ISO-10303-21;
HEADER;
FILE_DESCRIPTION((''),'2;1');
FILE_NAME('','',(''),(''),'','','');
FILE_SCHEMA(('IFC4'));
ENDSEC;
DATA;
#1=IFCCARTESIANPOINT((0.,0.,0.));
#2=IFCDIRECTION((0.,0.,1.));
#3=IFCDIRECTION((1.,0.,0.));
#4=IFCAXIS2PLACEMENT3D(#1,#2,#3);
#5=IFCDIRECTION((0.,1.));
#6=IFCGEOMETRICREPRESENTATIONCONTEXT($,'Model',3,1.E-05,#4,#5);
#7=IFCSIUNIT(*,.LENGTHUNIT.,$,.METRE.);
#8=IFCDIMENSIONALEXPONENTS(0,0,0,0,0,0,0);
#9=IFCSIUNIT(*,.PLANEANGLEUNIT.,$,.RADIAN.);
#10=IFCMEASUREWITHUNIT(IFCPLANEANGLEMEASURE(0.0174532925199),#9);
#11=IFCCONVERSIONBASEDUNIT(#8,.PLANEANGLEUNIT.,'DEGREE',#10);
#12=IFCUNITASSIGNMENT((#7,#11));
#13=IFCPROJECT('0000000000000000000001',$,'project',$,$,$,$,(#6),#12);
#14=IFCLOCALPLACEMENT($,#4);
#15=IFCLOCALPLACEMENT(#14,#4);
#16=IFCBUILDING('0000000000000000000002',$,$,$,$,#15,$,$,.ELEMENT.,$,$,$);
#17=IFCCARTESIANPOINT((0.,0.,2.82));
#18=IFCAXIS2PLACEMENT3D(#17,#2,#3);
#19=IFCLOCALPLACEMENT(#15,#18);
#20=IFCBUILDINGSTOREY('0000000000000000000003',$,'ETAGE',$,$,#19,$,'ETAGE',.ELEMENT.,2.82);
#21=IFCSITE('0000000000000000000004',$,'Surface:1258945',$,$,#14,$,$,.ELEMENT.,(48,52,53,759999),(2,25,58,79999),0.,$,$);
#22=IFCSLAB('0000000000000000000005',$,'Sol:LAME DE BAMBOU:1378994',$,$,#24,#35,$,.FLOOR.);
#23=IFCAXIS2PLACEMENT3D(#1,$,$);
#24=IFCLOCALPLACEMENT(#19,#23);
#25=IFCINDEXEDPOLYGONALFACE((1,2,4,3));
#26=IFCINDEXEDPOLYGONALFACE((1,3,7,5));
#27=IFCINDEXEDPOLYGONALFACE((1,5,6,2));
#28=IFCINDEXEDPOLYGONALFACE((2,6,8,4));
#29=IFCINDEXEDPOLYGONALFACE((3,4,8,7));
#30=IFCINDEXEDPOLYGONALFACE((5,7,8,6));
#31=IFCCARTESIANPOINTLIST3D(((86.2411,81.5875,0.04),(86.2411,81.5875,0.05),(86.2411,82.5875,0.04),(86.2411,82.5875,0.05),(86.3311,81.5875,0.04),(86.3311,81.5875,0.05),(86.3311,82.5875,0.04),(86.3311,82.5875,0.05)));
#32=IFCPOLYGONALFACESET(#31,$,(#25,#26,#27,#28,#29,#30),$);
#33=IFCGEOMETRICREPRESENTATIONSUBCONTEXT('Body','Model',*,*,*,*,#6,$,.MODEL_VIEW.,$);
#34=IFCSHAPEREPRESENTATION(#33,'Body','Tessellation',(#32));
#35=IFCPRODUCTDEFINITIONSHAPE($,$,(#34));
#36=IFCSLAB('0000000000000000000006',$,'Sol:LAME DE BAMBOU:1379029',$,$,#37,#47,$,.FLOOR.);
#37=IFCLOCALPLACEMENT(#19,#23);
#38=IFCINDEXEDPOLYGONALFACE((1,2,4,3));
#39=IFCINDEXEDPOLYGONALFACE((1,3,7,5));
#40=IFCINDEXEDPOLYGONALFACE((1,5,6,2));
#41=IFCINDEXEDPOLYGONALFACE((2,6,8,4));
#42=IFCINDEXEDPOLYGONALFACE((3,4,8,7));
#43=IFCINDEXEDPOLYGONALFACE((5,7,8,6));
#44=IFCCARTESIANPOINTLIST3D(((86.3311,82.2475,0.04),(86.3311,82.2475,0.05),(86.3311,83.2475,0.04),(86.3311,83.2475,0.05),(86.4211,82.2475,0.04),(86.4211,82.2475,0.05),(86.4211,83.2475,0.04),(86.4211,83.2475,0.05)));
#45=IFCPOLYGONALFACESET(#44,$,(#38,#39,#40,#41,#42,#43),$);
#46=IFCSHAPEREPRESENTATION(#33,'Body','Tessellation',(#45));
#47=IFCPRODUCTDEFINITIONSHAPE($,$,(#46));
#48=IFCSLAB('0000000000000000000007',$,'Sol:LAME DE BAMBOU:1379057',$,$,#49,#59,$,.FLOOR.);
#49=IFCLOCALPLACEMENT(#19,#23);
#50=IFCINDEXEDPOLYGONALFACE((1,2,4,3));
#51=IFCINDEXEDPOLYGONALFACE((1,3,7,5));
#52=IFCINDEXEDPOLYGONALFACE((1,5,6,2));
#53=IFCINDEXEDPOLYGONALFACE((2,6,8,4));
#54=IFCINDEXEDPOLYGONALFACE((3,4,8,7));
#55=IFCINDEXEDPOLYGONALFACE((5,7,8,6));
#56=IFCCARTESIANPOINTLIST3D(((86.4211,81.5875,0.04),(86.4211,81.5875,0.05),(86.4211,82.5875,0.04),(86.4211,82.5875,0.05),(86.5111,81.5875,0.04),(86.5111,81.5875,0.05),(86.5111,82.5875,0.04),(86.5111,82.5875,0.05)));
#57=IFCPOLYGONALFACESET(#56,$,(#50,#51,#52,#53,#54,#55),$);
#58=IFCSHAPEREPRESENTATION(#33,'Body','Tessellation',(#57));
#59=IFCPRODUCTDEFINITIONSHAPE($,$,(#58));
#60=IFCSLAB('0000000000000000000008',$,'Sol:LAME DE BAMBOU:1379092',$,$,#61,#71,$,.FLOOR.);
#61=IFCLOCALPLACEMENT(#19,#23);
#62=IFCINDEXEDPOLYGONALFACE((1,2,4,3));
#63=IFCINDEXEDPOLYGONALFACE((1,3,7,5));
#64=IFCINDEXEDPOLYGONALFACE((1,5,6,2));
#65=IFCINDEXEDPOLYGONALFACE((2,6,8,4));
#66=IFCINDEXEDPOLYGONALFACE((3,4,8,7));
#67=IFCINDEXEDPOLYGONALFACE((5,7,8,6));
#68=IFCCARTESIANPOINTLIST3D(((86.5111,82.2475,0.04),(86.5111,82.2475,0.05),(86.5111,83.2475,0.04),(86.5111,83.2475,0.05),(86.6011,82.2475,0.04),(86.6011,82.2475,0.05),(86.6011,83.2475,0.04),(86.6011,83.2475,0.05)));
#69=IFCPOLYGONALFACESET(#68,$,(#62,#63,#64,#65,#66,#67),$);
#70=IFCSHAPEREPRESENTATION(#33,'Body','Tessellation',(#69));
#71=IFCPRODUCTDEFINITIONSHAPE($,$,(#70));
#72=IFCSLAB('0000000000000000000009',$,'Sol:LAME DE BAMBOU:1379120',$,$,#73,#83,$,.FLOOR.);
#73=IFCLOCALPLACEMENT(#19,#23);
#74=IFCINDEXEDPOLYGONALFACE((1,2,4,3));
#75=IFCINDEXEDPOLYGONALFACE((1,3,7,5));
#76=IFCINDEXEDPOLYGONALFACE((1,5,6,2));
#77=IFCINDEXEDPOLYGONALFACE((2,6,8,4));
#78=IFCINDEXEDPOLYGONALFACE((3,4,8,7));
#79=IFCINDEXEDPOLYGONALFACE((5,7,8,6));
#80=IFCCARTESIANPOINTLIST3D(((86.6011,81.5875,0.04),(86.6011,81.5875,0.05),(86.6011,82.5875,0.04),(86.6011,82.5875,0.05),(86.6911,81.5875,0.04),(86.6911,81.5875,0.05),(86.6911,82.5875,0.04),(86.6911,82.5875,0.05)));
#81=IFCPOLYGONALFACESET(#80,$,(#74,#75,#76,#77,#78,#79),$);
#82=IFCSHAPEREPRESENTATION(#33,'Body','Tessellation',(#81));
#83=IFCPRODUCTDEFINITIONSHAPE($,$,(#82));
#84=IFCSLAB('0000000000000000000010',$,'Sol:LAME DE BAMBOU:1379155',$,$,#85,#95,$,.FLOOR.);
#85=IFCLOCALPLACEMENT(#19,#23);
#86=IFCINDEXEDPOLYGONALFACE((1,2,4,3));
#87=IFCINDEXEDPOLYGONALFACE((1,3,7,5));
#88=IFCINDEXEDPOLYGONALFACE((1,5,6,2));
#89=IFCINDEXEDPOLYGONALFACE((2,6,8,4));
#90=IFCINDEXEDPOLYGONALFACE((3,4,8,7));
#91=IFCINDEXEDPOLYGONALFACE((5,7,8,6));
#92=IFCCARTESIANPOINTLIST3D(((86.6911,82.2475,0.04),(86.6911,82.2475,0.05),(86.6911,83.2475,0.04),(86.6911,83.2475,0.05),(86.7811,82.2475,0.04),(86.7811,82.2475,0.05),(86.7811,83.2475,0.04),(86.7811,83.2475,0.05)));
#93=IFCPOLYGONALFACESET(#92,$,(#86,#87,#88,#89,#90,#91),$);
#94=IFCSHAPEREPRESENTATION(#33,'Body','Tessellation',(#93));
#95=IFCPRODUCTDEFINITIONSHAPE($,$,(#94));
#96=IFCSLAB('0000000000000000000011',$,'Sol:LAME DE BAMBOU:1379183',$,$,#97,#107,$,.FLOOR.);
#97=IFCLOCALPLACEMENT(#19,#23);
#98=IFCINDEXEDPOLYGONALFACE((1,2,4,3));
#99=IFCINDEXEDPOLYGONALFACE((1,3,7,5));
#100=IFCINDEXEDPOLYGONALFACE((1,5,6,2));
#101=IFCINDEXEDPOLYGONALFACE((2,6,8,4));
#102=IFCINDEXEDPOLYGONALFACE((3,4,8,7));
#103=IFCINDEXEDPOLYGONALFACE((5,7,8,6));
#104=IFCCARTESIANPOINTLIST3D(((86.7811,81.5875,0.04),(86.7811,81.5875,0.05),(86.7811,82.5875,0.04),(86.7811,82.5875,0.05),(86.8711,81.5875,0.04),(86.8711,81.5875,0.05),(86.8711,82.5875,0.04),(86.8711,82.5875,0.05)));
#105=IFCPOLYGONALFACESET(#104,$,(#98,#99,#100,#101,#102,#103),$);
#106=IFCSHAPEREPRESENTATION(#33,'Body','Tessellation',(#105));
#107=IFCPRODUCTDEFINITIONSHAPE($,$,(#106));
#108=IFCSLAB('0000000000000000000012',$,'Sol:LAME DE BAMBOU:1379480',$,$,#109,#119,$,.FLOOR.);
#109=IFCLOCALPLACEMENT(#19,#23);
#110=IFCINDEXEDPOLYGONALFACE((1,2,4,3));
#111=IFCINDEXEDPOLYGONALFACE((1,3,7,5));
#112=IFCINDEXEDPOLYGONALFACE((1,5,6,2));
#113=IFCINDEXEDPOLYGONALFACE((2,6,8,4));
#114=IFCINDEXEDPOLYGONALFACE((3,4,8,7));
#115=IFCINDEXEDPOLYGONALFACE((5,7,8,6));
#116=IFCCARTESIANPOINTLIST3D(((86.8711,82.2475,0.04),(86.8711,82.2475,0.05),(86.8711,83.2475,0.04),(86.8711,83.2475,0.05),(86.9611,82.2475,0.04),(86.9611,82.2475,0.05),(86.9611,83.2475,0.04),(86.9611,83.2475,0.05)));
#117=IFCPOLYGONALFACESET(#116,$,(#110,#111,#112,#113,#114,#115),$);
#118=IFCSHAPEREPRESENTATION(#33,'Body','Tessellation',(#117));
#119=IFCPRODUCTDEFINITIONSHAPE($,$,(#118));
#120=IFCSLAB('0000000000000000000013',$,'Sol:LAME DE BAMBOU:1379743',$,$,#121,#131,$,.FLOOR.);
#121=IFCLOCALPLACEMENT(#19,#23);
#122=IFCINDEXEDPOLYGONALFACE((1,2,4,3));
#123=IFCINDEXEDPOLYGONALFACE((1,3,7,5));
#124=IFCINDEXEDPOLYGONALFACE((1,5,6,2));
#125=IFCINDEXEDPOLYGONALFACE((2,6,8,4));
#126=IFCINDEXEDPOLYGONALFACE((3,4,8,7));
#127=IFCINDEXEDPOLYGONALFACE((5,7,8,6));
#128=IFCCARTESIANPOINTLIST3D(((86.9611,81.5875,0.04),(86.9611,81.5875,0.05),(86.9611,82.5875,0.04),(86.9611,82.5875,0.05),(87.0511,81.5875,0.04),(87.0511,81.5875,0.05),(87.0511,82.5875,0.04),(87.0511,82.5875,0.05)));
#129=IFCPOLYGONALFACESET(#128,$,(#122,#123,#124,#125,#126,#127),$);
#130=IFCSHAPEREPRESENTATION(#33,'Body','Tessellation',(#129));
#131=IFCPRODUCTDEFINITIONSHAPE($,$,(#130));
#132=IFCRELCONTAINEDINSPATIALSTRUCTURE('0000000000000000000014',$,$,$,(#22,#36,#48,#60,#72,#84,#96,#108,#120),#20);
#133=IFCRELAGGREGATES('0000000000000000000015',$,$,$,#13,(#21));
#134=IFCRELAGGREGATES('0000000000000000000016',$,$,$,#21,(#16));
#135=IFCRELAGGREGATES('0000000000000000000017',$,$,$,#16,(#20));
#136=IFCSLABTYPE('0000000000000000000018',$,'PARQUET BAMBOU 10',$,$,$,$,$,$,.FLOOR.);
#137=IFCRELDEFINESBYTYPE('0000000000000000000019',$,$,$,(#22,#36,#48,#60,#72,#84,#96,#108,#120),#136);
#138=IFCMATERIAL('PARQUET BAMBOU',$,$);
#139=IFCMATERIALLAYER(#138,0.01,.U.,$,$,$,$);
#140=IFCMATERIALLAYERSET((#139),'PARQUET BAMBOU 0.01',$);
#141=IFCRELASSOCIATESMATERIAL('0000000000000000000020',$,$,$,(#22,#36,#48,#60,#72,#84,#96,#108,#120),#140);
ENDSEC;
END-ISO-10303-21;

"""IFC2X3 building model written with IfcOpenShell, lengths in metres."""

from ifc_helpers import new_model, entity, si_unit, converted_unit, direction, frame, origin_with_axes, place, context, subcontext, project, spatial, polyline, outline, extrude, material, layer, layer_set, layer_usage, type_object, element, save


model = new_model("IFC2X3")

# Units and contexts
model_context = context("Model", 3, precision=1e-05, world=origin_with_axes(), true_north=direction((0.0, 1.0)))
body_context = subcontext(model_context, "Body", "Model", "MODEL_VIEW")
ifc_project = project(units=[si_unit("LENGTHUNIT", "METRE"), converted_unit("PLANEANGLEUNIT", "DEGREE", entity("IfcPlaneAngleMeasure", 0.0174532925199), si_unit("PLANEANGLEUNIT", "RADIAN"), dimensions=[0, 0, 0, 0, 0, 0, 0])], contexts=[model_context])

# Site, building, storey
site_placement = place(None, origin_with_axes())
site = spatial("IfcSite", under=ifc_project, at=site_placement, Name="Surface:1258945", CompositionType="ELEMENT", RefLatitude=(48, 52, 53, 759999), RefLongitude=(2, 25, 58, 79999), RefElevation=0.0)
building_placement = place(site_placement, origin_with_axes())
building = spatial("IfcBuilding", under=site, at=building_placement, CompositionType="ELEMENT")
storey_placement = place(building_placement, frame((0.0, 0.0, 2.82), z_axis=(0.0, 0.0, 1.0), x_axis=(1.0, 0.0, 0.0)))
storey = spatial("IfcBuildingStorey", under=building, at=storey_placement, Name="ETAGE", LongName="ETAGE", CompositionType="ELEMENT", Elevation=2.82)

# Slabs
ifc_material = material(Name="PARQUET BAMBOU")
ifc_layer = layer(ifc_material, 0.01, ventilated="UNKNOWN")
ifc_layer_set = layer_set([ifc_layer], Name="PARQUET BAMBOU 0.01")
slab_type = type_object("IfcSlabType", Name="PARQUET BAMBOU 10", PredefinedType="FLOOR")
ifc_layer_usage_1 = layer_usage(ifc_layer_set, "AXIS3", "NEGATIVE", 0.01)
slab_1_placement = place(storey_placement, frame((86.2411, 82.5875, 0.05), z_axis=(0.0, 0.0, 1.0), x_axis=(1.0, 0.0, 0.0)))
element("IfcSlab", 1, at=slab_1_placement, inside=storey, type_object=slab_type, material=ifc_layer_usage_1, Name="Sol:LAME DE BAMBOU:1378994", PredefinedType="FLOOR", context=body_context, shape_type="SweptSolid", body=[
    extrude(outline(polyline([(0.0, 0.0), (0.0, -1.0), (0.09, -1.0), (0.09, 0.0), (0.0, 0.0)])), frame((0.0, 0.0, -0.01), z_axis=(0.0, 0.0, 1.0), x_axis=(1.0, 0.0, 0.0)), (0.0, 0.0, 1.0), 0.01),
])
ifc_layer_usage_2 = layer_usage(ifc_layer_set, "AXIS3", "NEGATIVE", 0.01)
slab_2_placement = place(storey_placement, frame((86.3311, 83.2475, 0.05), z_axis=(0.0, 0.0, 1.0), x_axis=(1.0, 0.0, 0.0)))
element("IfcSlab", 2, at=slab_2_placement, inside=storey, type_object=slab_type, material=ifc_layer_usage_2, Name="Sol:LAME DE BAMBOU:1379029", PredefinedType="FLOOR", context=body_context, shape_type="SweptSolid", body=[
    extrude(outline(polyline([(0.0, 0.0), (0.0, -1.0), (0.09, -1.0), (0.09, 0.0), (0.0, 0.0)])), frame((0.0, 0.0, -0.01), z_axis=(0.0, 0.0, 1.0), x_axis=(1.0, 0.0, 0.0)), (0.0, 0.0, 1.0), 0.01),
])
ifc_layer_usage_3 = layer_usage(ifc_layer_set, "AXIS3", "NEGATIVE", 0.01)
slab_3_placement = place(storey_placement, frame((86.4211, 82.5875, 0.05), z_axis=(0.0, 0.0, 1.0), x_axis=(1.0, 0.0, 0.0)))
element("IfcSlab", 3, at=slab_3_placement, inside=storey, type_object=slab_type, material=ifc_layer_usage_3, Name="Sol:LAME DE BAMBOU:1379057", PredefinedType="FLOOR", context=body_context, shape_type="SweptSolid", body=[
    extrude(outline(polyline([(0.0, 0.0), (0.0, -1.0), (0.09, -1.0), (0.09, 0.0), (0.0, 0.0)])), frame((0.0, 0.0, -0.01), z_axis=(0.0, 0.0, 1.0), x_axis=(1.0, 0.0, 0.0)), (0.0, 0.0, 1.0), 0.01),
])
ifc_layer_usage_4 = layer_usage(ifc_layer_set, "AXIS3", "NEGATIVE", 0.01)
slab_4_placement = place(storey_placement, frame((86.5111, 83.2475, 0.05), z_axis=(0.0, 0.0, 1.0), x_axis=(1.0, 0.0, 0.0)))
element("IfcSlab", 4, at=slab_4_placement, inside=storey, type_object=slab_type, material=ifc_layer_usage_4, Name="Sol:LAME DE BAMBOU:1379092", PredefinedType="FLOOR", context=body_context, shape_type="SweptSolid", body=[
    extrude(outline(polyline([(0.0, 0.0), (0.0, -1.0), (0.09, -1.0), (0.09, 0.0), (0.0, 0.0)])), frame((0.0, 0.0, -0.01), z_axis=(0.0, 0.0, 1.0), x_axis=(1.0, 0.0, 0.0)), (0.0, 0.0, 1.0), 0.01),
])
ifc_layer_usage_5 = layer_usage(ifc_layer_set, "AXIS3", "NEGATIVE", 0.01)
slab_5_placement = place(storey_placement, frame((86.6011, 82.5875, 0.05), z_axis=(0.0, 0.0, 1.0), x_axis=(1.0, 0.0, 0.0)))
element("IfcSlab", 5, at=slab_5_placement, inside=storey, type_object=slab_type, material=ifc_layer_usage_5, Name="Sol:LAME DE BAMBOU:1379120", PredefinedType="FLOOR", context=body_context, shape_type="SweptSolid", body=[
    extrude(outline(polyline([(0.0, 0.0), (0.0, -1.0), (0.09, -1.0), (0.09, 0.0), (0.0, 0.0)])), frame((0.0, 0.0, -0.01), z_axis=(0.0, 0.0, 1.0), x_axis=(1.0, 0.0, 0.0)), (0.0, 0.0, 1.0), 0.01),
])
ifc_layer_usage_6 = layer_usage(ifc_layer_set, "AXIS3", "NEGATIVE", 0.01)
slab_6_placement = place(storey_placement, frame((86.6911, 83.2475, 0.05), z_axis=(0.0, 0.0, 1.0), x_axis=(1.0, 0.0, 0.0)))
element("IfcSlab", 6, at=slab_6_placement, inside=storey, type_object=slab_type, material=ifc_layer_usage_6, Name="Sol:LAME DE BAMBOU:1379155", PredefinedType="FLOOR", context=body_context, shape_type="SweptSolid", body=[
    extrude(outline(polyline([(0.0, 0.0), (0.0, -1.0), (0.09, -1.0), (0.09, 0.0), (0.0, 0.0)])), frame((0.0, 0.0, -0.01), z_axis=(0.0, 0.0, 1.0), x_axis=(1.0, 0.0, 0.0)), (0.0, 0.0, 1.0), 0.01),
])
ifc_layer_usage_7 = layer_usage(ifc_layer_set, "AXIS3", "NEGATIVE", 0.01)
slab_7_placement = place(storey_placement, frame((86.7811, 82.5875, 0.05), z_axis=(0.0, 0.0, 1.0), x_axis=(1.0, 0.0, 0.0)))
element("IfcSlab", 7, at=slab_7_placement, inside=storey, type_object=slab_type, material=ifc_layer_usage_7, Name="Sol:LAME DE BAMBOU:1379183", PredefinedType="FLOOR", context=body_context, shape_type="SweptSolid", body=[
    extrude(outline(polyline([(0.0, 0.0), (0.0, -1.0), (0.09, -1.0), (0.09, 0.0), (0.0, 0.0)])), frame((0.0, 0.0, -0.01), z_axis=(0.0, 0.0, 1.0), x_axis=(1.0, 0.0, 0.0)), (0.0, 0.0, 1.0), 0.01),
])
ifc_layer_usage_8 = layer_usage(ifc_layer_set, "AXIS3", "NEGATIVE", 0.01)
slab_8_placement = place(storey_placement, frame((86.8711, 83.2475, 0.05), z_axis=(0.0, 0.0, 1.0), x_axis=(1.0, 0.0, 0.0)))
element("IfcSlab", 8, at=slab_8_placement, inside=storey, type_object=slab_type, material=ifc_layer_usage_8, Name="Sol:LAME DE BAMBOU:1379480", PredefinedType="FLOOR", context=body_context, shape_type="SweptSolid", body=[
    extrude(outline(polyline([(0.0, 0.0), (0.0, -1.0), (0.09, -1.0), (0.09, 0.0), (0.0, 0.0)])), frame((0.0, 0.0, -0.01), z_axis=(0.0, 0.0, 1.0), x_axis=(1.0, 0.0, 0.0)), (0.0, 0.0, 1.0), 0.01),
])
ifc_layer_usage_9 = layer_usage(ifc_layer_set, "AXIS3", "NEGATIVE", 0.01)
slab_9_placement = place(storey_placement, frame((86.9611, 82.5875, 0.05), z_axis=(0.0, 0.0, 1.0), x_axis=(1.0, 0.0, 0.0)))
element("IfcSlab", 9, at=slab_9_placement, inside=storey, type_object=slab_type, material=ifc_layer_usage_9, Name="Sol:LAME DE BAMBOU:1379743", PredefinedType="FLOOR", context=body_context, shape_type="SweptSolid", body=[
    extrude(outline(polyline([(0.0, 0.0), (0.0, -1.0), (0.09, -1.0), (0.09, 0.0), (0.0, 0.0)])), frame((0.0, 0.0, -0.01), z_axis=(0.0, 0.0, 1.0), x_axis=(1.0, 0.0, 0.0)), (0.0, 0.0, 1.0), 0.01),
])

save(model, "model.ifc")
